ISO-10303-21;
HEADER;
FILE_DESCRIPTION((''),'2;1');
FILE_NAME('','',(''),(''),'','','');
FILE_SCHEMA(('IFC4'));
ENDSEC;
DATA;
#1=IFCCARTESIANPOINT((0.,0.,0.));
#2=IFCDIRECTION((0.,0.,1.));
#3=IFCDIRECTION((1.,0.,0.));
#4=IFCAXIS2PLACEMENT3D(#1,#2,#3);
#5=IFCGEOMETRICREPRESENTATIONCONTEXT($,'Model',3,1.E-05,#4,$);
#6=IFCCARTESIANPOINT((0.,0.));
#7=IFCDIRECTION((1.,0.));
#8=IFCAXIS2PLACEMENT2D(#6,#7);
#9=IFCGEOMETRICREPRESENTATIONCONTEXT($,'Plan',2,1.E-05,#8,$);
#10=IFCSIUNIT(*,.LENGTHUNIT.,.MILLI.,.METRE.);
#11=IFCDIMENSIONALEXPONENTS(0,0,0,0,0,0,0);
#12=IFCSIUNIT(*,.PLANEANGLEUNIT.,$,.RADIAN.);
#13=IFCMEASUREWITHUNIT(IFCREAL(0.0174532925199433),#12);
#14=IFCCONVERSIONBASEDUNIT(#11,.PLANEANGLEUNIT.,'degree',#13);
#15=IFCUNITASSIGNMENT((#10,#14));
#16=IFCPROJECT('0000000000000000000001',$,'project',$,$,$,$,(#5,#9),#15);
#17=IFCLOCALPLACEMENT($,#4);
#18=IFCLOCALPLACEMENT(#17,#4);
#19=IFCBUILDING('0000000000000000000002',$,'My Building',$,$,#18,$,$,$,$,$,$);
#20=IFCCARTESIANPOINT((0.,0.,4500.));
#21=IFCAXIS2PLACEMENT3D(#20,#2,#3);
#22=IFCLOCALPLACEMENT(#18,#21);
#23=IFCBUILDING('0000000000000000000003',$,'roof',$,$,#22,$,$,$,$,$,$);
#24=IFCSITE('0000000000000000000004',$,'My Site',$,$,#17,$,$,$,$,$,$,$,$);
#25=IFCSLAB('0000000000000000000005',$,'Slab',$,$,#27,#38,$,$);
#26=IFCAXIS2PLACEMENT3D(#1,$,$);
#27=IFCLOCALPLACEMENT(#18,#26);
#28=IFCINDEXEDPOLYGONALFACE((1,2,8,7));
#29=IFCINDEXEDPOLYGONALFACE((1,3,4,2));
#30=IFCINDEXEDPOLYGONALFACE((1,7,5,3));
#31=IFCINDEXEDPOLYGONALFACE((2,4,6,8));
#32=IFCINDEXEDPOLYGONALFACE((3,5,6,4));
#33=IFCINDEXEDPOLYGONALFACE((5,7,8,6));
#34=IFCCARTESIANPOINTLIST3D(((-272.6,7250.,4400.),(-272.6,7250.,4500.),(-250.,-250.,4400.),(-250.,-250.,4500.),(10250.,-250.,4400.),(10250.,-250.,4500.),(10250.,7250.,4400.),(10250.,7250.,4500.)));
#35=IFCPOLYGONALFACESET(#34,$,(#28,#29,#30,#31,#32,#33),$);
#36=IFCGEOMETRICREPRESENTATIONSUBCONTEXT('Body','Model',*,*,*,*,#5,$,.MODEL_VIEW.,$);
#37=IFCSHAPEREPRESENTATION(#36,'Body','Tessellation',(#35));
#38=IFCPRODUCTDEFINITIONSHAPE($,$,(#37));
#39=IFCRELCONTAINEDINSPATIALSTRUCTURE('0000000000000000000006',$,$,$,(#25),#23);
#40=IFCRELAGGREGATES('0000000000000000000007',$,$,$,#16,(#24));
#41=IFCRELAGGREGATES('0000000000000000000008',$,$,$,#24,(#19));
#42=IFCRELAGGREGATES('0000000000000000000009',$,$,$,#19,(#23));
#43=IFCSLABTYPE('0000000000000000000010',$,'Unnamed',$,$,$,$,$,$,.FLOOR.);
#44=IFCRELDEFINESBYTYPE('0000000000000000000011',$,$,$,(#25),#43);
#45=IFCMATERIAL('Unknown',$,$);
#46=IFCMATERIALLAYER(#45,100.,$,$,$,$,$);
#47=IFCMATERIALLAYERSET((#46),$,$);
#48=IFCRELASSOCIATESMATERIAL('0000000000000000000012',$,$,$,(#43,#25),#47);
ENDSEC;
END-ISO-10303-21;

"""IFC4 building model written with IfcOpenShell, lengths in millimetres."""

from ifc_helpers import new_model, entity, si_unit, converted_unit, frame, origin_with_axes, origin_2d_with_axis, place, context, subcontext, project, spatial, indexed_curve, outline, extrude, material, layer, layer_set, layer_usage, type_object, element, save


model = new_model("IFC4")

# Units and contexts
model_context = context("Model", 3, precision=1e-05, world=origin_with_axes())
plan_context = context("Plan", 2, precision=1e-05, world=origin_2d_with_axis())
body_context = subcontext(model_context, "Body", "Model", "MODEL_VIEW")
ifc_project = project(units=[si_unit("LENGTHUNIT", "METRE", prefix="MILLI"), converted_unit("PLANEANGLEUNIT", "degree", entity("IfcReal", 0.0174532925199433), si_unit("PLANEANGLEUNIT", "RADIAN"), dimensions=[0, 0, 0, 0, 0, 0, 0])], contexts=[model_context, plan_context])

# Site, buildings
site_placement = place(None, origin_with_axes())
site = spatial("IfcSite", under=ifc_project, at=site_placement, Name="My Site")
building_1_placement = place(site_placement, origin_with_axes())
building_1 = spatial("IfcBuilding", under=site, at=building_1_placement, Name="My Building")
building_2_placement = place(building_1_placement, frame((0.0, 0.0, 4500.0), z_axis=(0.0, 0.0, 1.0), x_axis=(1.0, 0.0, 0.0)))
building_2 = spatial("IfcBuilding", under=building_1, at=building_2_placement, Name="roof")

# Slab
ifc_material = material(Name="Unknown")
ifc_layer = layer(ifc_material, 100.0)
ifc_layer_set = layer_set([ifc_layer])
ifc_layer_usage = layer_usage(ifc_layer_set, "AXIS3", "POSITIVE", -100.0)
slab_type = type_object("IfcSlabType", Name="Unnamed", PredefinedType="FLOOR", material=ifc_layer_set)
slab_placement = place(building_2_placement, frame((-272.6, 7250.0, 0.0), z_axis=(0.0, 0.0, 1.0), x_axis=(1.0, 0.0, 0.0)))
element("IfcSlab", 1, at=slab_placement, inside=building_2, type_object=slab_type, material=ifc_layer_usage, Name="Slab", context=body_context, shape_type="SweptSolid", body=[
    extrude(outline(indexed_curve([(0.0, 0.0), (10522.6, 0.0), (10522.6, -7500.0), (22.6, -7500.0), (0.0, 0.0)])), frame((0.0, 0.0, -100.0), z_axis=(0.0, 0.0, 1.0), x_axis=(1.0, 0.0, 0.0)), (0.0, 0.0, 1.0), 100.0),
])

save(model, "model.ifc")
